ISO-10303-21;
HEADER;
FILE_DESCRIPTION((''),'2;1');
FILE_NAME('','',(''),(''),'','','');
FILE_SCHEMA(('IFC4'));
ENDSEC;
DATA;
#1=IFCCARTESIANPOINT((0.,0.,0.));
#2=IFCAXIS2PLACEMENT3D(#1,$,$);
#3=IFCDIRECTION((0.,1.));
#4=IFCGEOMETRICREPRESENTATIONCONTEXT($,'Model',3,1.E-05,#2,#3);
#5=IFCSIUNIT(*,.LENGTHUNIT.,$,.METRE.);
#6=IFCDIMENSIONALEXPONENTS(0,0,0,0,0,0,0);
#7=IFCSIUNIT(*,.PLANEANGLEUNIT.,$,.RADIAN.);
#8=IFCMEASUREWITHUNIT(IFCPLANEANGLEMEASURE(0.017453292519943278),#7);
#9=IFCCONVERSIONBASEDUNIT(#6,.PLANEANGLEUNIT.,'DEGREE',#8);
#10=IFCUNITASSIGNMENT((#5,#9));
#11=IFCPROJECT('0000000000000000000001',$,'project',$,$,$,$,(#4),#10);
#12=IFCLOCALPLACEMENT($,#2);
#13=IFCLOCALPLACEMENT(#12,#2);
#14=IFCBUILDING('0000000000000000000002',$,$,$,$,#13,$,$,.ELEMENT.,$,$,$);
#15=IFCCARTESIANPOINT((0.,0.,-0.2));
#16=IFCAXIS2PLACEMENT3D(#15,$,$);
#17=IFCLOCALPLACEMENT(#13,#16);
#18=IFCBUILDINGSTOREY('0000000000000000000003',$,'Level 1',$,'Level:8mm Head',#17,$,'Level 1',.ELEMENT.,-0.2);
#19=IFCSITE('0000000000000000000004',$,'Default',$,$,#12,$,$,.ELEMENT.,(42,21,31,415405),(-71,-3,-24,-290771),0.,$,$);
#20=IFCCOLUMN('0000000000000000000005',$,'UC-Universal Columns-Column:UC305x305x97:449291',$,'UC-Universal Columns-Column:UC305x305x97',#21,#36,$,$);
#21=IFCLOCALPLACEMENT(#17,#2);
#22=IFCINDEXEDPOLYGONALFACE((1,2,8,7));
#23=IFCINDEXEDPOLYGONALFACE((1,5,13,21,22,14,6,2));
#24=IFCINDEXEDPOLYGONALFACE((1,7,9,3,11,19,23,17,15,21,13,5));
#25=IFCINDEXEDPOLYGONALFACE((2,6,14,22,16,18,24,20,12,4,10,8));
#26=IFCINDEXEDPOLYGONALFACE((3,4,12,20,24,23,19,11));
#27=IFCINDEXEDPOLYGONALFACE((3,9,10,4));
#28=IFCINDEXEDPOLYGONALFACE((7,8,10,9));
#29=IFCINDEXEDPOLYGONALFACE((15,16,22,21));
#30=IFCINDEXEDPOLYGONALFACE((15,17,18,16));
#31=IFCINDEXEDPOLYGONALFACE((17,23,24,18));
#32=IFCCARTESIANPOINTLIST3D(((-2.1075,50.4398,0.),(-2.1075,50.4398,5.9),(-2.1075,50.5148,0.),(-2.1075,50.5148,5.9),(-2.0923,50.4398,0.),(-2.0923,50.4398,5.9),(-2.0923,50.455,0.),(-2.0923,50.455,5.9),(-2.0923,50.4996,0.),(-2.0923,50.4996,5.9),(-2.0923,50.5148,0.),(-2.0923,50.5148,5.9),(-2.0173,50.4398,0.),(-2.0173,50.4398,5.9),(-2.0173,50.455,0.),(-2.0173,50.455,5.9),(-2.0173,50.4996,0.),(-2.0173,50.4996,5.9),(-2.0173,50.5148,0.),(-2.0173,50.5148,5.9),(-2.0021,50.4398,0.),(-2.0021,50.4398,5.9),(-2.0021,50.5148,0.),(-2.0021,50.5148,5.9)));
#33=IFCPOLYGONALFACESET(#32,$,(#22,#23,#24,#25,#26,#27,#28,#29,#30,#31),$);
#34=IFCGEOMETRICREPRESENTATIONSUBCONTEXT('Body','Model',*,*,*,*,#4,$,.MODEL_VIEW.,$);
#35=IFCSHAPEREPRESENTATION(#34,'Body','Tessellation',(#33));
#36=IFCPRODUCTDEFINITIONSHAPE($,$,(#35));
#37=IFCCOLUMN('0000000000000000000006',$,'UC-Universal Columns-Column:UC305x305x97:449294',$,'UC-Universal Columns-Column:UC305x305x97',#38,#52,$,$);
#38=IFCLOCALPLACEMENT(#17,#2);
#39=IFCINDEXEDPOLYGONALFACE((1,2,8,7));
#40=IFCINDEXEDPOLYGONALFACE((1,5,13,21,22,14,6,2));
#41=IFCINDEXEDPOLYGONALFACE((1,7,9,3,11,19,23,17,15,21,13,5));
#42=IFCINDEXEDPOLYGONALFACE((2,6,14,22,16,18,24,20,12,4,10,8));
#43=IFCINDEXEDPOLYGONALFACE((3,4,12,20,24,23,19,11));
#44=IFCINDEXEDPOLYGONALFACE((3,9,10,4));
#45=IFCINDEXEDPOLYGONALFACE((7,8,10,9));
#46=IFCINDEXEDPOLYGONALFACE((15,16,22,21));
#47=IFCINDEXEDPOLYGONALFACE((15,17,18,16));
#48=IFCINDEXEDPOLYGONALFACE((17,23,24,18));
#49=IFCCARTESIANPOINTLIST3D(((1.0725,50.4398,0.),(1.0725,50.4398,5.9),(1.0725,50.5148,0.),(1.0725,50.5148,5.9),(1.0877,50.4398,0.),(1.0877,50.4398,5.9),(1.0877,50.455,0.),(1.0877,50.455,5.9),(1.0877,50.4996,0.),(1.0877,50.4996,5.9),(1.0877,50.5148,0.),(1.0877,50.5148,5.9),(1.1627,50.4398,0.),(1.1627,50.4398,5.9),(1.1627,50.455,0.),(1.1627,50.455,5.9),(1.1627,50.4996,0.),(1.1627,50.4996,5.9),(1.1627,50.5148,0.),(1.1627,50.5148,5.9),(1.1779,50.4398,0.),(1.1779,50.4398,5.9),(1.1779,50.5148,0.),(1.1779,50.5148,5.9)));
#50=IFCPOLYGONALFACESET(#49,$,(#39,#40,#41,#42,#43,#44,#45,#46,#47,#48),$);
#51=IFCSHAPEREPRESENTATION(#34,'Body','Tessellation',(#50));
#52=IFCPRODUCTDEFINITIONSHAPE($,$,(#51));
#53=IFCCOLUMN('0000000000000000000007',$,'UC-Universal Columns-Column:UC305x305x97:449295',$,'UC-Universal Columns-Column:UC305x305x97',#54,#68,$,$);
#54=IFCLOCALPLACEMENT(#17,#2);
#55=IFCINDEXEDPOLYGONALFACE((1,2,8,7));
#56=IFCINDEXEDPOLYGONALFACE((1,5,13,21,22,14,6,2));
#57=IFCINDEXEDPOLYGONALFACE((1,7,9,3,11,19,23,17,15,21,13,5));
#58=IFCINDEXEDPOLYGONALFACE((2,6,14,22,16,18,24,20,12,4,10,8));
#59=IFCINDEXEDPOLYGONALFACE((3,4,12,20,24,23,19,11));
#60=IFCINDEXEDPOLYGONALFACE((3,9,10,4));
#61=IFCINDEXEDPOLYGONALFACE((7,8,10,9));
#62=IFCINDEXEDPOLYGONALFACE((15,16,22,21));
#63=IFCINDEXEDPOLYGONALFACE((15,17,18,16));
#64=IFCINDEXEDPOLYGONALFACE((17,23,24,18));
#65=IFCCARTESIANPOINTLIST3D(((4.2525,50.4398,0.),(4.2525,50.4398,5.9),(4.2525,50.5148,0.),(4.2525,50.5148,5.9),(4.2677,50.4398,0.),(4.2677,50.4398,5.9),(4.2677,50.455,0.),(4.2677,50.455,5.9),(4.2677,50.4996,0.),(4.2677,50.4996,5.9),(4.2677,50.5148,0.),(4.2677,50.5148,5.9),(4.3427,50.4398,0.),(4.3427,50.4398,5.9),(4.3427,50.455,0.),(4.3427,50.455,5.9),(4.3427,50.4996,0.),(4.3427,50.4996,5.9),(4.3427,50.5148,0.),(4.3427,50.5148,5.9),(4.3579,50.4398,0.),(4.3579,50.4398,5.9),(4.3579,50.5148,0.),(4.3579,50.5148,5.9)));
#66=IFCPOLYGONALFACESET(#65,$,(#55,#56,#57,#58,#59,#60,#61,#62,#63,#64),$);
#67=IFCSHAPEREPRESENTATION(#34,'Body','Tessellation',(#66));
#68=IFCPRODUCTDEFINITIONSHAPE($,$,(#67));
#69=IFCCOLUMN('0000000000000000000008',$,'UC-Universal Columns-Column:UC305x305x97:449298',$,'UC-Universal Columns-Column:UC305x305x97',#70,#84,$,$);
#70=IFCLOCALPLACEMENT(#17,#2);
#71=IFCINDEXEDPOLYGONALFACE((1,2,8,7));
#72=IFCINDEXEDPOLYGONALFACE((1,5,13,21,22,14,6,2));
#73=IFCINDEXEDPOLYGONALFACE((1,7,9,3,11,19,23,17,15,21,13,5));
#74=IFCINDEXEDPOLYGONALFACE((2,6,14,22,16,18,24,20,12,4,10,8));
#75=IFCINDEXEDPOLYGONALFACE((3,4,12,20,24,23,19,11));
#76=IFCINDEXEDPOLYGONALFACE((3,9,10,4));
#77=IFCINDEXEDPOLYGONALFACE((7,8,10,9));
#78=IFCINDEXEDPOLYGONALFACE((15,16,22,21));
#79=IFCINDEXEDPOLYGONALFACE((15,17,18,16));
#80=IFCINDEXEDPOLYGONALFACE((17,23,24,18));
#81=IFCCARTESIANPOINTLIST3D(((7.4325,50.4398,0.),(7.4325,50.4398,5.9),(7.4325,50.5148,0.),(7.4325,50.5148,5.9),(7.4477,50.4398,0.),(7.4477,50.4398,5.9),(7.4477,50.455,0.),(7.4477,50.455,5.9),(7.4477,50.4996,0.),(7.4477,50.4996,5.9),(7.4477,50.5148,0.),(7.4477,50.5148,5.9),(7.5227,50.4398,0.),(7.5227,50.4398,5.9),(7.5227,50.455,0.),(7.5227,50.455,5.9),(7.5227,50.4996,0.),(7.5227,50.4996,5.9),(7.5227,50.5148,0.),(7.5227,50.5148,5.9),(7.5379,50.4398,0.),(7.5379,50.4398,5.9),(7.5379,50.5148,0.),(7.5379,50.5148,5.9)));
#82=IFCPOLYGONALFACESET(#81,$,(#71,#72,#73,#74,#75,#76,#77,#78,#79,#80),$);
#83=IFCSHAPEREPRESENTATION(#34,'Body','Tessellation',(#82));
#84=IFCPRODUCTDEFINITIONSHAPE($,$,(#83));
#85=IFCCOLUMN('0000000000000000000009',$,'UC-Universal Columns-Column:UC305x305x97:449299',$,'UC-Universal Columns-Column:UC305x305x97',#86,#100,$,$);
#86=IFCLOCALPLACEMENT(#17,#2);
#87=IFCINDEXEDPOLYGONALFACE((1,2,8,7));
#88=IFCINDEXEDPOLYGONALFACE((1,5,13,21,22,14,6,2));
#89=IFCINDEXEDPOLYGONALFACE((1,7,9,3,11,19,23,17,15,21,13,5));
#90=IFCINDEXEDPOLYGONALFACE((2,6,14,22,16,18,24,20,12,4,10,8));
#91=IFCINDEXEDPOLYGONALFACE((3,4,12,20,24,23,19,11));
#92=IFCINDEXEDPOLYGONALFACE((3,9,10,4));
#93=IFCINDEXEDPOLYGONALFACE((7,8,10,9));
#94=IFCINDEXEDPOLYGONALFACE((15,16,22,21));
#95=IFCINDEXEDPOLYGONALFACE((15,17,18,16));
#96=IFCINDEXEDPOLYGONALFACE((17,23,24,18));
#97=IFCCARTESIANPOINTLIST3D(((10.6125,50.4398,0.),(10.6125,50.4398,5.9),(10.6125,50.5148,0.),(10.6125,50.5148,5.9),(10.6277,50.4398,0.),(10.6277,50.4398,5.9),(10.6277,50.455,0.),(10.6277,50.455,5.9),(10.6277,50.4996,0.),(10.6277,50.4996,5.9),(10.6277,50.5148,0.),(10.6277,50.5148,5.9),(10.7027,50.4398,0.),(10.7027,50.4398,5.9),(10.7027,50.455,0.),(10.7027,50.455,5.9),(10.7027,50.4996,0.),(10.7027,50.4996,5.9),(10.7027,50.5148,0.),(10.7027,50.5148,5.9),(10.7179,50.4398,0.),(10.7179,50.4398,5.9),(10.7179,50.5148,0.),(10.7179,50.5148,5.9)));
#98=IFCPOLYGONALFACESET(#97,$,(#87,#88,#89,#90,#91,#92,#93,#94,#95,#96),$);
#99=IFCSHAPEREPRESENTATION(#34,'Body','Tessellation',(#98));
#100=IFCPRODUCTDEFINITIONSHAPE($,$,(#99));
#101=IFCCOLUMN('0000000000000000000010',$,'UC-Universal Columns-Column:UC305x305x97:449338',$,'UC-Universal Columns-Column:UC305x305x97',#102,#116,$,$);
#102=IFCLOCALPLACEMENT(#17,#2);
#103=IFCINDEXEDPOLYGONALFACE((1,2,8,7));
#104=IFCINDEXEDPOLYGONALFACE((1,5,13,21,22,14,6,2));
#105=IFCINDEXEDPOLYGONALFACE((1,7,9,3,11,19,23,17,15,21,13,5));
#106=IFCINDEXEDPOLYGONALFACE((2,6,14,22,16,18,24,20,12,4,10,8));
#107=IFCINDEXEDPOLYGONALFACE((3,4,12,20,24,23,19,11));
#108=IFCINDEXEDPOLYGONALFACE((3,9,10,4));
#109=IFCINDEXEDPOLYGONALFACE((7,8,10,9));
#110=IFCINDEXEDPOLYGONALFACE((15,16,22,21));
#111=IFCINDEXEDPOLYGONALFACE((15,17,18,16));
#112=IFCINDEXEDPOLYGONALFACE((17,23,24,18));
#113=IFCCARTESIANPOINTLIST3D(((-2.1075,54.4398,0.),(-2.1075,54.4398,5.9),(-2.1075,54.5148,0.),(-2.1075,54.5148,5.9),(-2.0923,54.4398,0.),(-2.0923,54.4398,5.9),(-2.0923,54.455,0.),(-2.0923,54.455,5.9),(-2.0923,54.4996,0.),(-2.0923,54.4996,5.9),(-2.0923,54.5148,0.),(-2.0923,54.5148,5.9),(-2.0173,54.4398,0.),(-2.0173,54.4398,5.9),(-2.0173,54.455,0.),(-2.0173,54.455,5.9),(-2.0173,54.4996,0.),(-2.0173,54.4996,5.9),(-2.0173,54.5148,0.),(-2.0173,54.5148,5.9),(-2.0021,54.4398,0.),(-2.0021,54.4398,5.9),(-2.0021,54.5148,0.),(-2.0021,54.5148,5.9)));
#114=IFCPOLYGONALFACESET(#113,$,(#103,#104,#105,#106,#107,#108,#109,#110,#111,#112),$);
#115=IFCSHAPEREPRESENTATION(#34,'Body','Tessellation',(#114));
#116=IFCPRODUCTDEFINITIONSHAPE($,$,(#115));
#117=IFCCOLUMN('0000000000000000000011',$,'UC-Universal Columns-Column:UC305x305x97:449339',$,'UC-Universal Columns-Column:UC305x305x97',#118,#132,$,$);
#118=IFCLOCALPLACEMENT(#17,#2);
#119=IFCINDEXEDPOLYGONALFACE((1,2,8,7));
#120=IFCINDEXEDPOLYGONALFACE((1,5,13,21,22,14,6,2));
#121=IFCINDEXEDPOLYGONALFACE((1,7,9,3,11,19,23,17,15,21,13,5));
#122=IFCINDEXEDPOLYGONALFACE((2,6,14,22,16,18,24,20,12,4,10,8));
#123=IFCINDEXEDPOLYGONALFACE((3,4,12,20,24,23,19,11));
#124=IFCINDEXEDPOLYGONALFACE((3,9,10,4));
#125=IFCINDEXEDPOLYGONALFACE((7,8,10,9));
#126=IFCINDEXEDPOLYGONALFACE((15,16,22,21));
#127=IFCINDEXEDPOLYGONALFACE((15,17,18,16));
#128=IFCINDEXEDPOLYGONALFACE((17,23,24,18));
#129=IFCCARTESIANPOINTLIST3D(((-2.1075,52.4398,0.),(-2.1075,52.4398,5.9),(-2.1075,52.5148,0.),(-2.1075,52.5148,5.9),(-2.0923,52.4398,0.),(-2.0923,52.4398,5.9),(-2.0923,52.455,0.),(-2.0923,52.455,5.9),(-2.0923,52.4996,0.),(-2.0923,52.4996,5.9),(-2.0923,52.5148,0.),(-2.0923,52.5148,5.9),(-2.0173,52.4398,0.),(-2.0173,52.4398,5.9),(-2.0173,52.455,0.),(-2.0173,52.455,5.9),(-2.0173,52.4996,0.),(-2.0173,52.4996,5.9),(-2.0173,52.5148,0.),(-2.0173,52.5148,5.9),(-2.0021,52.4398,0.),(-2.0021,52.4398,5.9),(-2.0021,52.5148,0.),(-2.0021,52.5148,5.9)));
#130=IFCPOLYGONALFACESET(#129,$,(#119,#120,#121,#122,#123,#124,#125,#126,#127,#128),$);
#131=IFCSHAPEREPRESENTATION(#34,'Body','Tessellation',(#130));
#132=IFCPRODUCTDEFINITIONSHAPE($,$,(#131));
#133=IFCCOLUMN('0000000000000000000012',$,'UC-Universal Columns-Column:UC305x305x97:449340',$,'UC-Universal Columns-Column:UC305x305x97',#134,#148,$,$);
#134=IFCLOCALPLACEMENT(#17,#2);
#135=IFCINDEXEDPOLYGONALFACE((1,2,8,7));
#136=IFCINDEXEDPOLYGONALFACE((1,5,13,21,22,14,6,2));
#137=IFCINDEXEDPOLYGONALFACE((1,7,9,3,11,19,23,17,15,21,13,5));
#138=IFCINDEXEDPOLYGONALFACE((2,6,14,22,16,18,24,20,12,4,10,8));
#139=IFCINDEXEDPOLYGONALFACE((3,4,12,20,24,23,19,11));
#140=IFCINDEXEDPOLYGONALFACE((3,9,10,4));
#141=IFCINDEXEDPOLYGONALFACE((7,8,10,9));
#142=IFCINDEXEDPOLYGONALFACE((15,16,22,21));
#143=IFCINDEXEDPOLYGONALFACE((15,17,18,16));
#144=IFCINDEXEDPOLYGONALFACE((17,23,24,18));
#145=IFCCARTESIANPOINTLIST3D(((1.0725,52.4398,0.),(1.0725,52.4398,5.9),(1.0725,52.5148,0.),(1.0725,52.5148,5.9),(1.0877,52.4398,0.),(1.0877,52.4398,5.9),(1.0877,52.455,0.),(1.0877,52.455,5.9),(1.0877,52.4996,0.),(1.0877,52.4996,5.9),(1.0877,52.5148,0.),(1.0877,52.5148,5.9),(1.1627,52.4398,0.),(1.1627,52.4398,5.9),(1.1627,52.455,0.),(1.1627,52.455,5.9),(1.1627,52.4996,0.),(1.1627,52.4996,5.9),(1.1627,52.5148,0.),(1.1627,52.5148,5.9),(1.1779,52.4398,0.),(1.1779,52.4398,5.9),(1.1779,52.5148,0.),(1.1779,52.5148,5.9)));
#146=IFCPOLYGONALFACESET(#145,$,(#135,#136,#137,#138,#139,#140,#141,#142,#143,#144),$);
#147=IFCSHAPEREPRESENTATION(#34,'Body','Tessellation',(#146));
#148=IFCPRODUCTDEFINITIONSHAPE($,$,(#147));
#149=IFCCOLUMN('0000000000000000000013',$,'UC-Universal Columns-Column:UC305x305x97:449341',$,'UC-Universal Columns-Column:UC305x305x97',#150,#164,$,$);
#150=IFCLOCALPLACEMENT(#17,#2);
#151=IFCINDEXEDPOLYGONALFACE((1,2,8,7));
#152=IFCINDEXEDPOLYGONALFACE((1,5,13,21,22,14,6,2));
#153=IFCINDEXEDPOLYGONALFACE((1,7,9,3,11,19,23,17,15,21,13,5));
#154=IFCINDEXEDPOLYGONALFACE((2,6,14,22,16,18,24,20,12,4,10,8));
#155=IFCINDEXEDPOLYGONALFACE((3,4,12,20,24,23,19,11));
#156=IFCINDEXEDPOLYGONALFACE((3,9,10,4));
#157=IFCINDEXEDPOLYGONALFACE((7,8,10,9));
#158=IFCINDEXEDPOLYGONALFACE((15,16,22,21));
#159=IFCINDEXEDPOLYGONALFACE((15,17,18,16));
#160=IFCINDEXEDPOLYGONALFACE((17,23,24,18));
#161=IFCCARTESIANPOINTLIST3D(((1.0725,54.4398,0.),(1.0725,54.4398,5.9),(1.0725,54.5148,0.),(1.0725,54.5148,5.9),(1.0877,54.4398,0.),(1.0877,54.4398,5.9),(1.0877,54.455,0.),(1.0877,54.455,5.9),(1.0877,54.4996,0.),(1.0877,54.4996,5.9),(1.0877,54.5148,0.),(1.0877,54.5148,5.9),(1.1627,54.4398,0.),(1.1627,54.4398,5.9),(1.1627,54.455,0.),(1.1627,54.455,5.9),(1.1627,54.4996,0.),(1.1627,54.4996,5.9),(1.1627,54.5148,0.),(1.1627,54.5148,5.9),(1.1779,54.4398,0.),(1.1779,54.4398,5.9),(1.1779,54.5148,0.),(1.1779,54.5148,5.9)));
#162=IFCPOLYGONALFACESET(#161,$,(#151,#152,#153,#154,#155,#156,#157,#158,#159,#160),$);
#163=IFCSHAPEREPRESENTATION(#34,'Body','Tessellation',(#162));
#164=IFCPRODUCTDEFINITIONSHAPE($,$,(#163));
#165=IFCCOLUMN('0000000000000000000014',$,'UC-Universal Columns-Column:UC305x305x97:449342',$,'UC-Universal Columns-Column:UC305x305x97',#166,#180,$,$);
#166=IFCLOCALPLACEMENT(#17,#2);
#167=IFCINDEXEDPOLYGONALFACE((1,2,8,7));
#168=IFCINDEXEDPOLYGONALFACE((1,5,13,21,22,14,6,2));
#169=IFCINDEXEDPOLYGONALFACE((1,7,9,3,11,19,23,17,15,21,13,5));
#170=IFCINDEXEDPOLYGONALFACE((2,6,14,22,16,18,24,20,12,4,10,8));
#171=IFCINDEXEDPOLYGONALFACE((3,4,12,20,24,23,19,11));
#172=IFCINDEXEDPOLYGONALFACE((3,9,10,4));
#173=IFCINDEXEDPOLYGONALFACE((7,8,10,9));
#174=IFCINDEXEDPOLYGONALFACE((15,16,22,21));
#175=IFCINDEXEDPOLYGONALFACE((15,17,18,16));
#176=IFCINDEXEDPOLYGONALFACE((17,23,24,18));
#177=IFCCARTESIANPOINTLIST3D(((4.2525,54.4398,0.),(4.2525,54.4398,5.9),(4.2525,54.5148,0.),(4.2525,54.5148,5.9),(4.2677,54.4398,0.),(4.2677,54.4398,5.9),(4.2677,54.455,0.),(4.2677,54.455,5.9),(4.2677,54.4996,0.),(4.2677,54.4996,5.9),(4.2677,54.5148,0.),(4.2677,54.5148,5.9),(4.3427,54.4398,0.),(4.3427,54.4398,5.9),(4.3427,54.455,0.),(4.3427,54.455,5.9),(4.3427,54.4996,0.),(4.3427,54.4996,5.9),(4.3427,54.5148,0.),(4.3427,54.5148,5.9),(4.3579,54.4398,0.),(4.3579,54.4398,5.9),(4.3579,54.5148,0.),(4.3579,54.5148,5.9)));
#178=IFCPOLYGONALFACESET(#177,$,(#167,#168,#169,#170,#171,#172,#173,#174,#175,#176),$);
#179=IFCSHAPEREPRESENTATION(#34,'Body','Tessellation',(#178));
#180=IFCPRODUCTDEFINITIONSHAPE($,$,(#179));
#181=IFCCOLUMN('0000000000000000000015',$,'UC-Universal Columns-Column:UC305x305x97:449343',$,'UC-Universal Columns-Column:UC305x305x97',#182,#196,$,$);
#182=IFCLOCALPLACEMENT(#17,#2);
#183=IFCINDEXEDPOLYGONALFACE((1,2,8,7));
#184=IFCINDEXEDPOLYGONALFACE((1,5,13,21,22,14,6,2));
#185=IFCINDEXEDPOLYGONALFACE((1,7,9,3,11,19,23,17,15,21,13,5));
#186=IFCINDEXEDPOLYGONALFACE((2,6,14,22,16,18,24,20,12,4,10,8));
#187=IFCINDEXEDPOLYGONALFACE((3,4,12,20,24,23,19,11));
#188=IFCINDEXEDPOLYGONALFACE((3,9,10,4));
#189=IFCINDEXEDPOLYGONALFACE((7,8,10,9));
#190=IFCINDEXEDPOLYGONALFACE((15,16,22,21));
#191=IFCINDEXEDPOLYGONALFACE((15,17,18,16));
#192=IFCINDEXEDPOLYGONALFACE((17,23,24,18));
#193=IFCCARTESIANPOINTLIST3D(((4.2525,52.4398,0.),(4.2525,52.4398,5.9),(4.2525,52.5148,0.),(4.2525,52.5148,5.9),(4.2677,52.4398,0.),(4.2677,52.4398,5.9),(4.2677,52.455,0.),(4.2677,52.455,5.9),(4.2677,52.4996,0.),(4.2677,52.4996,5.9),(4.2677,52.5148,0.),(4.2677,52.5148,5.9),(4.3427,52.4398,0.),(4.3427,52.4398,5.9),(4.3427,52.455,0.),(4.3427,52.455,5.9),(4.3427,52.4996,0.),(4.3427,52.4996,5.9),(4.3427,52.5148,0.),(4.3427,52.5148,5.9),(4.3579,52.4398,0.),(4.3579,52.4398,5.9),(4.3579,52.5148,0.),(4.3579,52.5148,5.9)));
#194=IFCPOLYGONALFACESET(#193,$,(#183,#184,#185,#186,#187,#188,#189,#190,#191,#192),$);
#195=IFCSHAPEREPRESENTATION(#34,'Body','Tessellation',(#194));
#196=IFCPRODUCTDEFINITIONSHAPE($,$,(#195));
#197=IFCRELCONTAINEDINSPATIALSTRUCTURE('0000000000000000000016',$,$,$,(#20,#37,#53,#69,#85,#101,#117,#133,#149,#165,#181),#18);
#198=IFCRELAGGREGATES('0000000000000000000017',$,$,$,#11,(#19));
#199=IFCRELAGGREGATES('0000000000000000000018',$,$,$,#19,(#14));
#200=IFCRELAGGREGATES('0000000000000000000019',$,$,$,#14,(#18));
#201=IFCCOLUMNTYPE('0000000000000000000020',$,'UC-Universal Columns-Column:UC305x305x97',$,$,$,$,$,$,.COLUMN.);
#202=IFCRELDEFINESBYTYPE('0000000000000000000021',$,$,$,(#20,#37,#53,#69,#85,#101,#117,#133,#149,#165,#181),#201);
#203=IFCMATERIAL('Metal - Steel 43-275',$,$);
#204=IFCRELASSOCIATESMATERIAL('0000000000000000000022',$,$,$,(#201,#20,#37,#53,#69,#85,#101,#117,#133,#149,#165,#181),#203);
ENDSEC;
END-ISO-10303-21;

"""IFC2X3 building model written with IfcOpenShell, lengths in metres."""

from ifc_helpers import new_model, entity, si_unit, converted_unit, direction, frame, frame_2d, origin, place, context, subcontext, project, spatial, polyline, circle_curve, parameter, trimmed, segment, composite_curve, outline, extrude, source, transform, mapped, material, type_object, type_shapes, element, save


model = new_model("IFC2X3")

# Units and contexts
model_context = context("Model", 3, precision=1e-05, world=origin(), true_north=direction((0.0, 1.0)))
body_context = subcontext(model_context, "Body", "Model", "MODEL_VIEW")
ifc_project = project(units=[si_unit("LENGTHUNIT", "METRE"), converted_unit("PLANEANGLEUNIT", "DEGREE", entity("IfcPlaneAngleMeasure", 0.017453292519943278), si_unit("PLANEANGLEUNIT", "RADIAN"), dimensions=[0, 0, 0, 0, 0, 0, 0])], contexts=[model_context])

# Site, building, storey
site_placement = place(None, origin())
site = spatial("IfcSite", under=ifc_project, at=site_placement, Name="Default", CompositionType="ELEMENT", RefLatitude=(42, 21, 31, 415405), RefLongitude=(-71, -3, -24, -290771), RefElevation=0.0)
building_placement = place(site_placement, origin())
building = spatial("IfcBuilding", under=site, at=building_placement, CompositionType="ELEMENT")
storey_placement = place(building_placement, frame((0.0, 0.0, -0.2)))
storey = spatial("IfcBuildingStorey", under=building, at=storey_placement, Name="Level 1", ObjectType="Level:8mm Head", LongName="Level 1", CompositionType="ELEMENT", Elevation=-0.2)

# Columns
ifc_material = material(Name="Metal - Steel 43-275")
column_type = type_object("IfcColumnType", Name="UC-Universal Columns-Column:UC305x305x97", PredefinedType="COLUMN", material=ifc_material)
shared_shape = source(origin(), body_context, "Body", "SweptSolid", [
    extrude(outline(composite_curve([segment(polyline([(-0.0375, -0.0375), (0.0375, -0.0375)]), True, "CONTINUOUS"), segment(polyline([(0.0375, -0.0375), (0.0527, -0.0375)]), True, "CONTINUOUS"), segment(trimmed(circle_curve(frame_2d((0.0527, -0.0223), x_axis=(-1.0, 0.0)), 0.0152), [parameter(0.0)], [parameter(90.0)], True, "PARAMETER"), False, "CONTINUOUS"), segment(polyline([(0.0375, -0.0223), (0.0375, 0.0223)]), True, "CONTINUOUS"), segment(trimmed(circle_curve(frame_2d((0.0527, 0.0223), x_axis=(-1.0, 0.0)), 0.0152), [parameter(270.0)], [parameter(0.0)], True, "PARAMETER"), False, "CONTINUOUS"), segment(polyline([(0.0527, 0.0375), (0.0375, 0.0375)]), True, "CONTINUOUS"), segment(polyline([(0.0375, 0.0375), (-0.0375, 0.0375)]), True, "CONTINUOUS"), segment(polyline([(-0.0375, 0.0375), (-0.0527, 0.0375)]), True, "CONTINUOUS"), segment(trimmed(circle_curve(frame_2d((-0.0527, 0.0223), x_axis=(-1.0, 0.0)), 0.0152), [parameter(180.0)], [parameter(270.0)], True, "PARAMETER"), False, "CONTINUOUS"), segment(polyline([(-0.0375, 0.0223), (-0.0375, -0.0223)]), True, "CONTINUOUS"), segment(trimmed(circle_curve(frame_2d((-0.0527, -0.0223), x_axis=(-1.0, 0.0)), 0.0152), [parameter(90.0)], [parameter(180.0)], True, "PARAMETER"), False, "CONTINUOUS"), segment(polyline([(-0.0527, -0.0375), (-0.0375, -0.0375)]), True, "CONTINUOUS")], self_intersect=False)), frame((0.0, 0.0, -0.2), z_axis=(0.0, 0.0, 1.0), x_axis=(-1.0, 0.0, 0.0)), (0.0, 0.0, 1.0), 5.9),
])
type_shapes(column_type, [shared_shape])
for number, where, z_axis, x_axis, name in (
    (1, (-2.0548, 50.4773, 0.2), (0.0, 0.0, 1.0), (-1.0, 0.0, 0.0), "UC-Universal Columns-Column:UC305x305x97:449291"),
    (2, (1.1252, 50.4773, 0.2), (0.0, 0.0, 1.0), (-1.0, 0.0, 0.0), "UC-Universal Columns-Column:UC305x305x97:449294"),
    (3, (4.3052, 50.4773, 0.2), (0.0, 0.0, 1.0), (-1.0, 0.0, 0.0), "UC-Universal Columns-Column:UC305x305x97:449295"),
    (4, (7.4852, 50.4773, 0.2), (0.0, 0.0, 1.0), (-1.0, 0.0, 0.0), "UC-Universal Columns-Column:UC305x305x97:449298"),
    (5, (10.6652, 50.4773, 0.2), (0.0, 0.0, 1.0), (-1.0, 0.0, 0.0), "UC-Universal Columns-Column:UC305x305x97:449299"),
    (6, (-2.0548, 54.4773, 0.2), (0.0, 0.0, 1.0), (-1.0, 0.0, 0.0), "UC-Universal Columns-Column:UC305x305x97:449338"),
    (7, (-2.0548, 52.4773, 0.2), (0.0, 0.0, 1.0), (-1.0, 0.0, 0.0), "UC-Universal Columns-Column:UC305x305x97:449339"),
    (8, (1.1252, 52.4773, 0.2), (0.0, 0.0, 1.0), (-1.0, 0.0, 0.0), "UC-Universal Columns-Column:UC305x305x97:449340"),
    (9, (1.1252, 54.4773, 0.2), (0.0, 0.0, 1.0), (-1.0, 0.0, 0.0), "UC-Universal Columns-Column:UC305x305x97:449341"),
    (10, (4.3052, 54.4773, 0.2), (0.0, 0.0, 1.0), (-1.0, 0.0, 0.0), "UC-Universal Columns-Column:UC305x305x97:449342"),
    (11, (4.3052, 52.4773, 0.2), (0.0, 0.0, 1.0), (-1.0, 0.0, 0.0), "UC-Universal Columns-Column:UC305x305x97:449343"),
):
    element("IfcColumn", number, at=place(storey_placement, frame(where, z_axis=z_axis, x_axis=x_axis)), inside=storey, type_object=column_type, material=ifc_material, Name=name, ObjectType="UC-Universal Columns-Column:UC305x305x97", context=body_context, shape_type="MappedRepresentation", body=[
        mapped(shared_shape, transform((0.0, 0.0, 0.0), scale=1.0)),
    ])

save(model, "model.ifc")
